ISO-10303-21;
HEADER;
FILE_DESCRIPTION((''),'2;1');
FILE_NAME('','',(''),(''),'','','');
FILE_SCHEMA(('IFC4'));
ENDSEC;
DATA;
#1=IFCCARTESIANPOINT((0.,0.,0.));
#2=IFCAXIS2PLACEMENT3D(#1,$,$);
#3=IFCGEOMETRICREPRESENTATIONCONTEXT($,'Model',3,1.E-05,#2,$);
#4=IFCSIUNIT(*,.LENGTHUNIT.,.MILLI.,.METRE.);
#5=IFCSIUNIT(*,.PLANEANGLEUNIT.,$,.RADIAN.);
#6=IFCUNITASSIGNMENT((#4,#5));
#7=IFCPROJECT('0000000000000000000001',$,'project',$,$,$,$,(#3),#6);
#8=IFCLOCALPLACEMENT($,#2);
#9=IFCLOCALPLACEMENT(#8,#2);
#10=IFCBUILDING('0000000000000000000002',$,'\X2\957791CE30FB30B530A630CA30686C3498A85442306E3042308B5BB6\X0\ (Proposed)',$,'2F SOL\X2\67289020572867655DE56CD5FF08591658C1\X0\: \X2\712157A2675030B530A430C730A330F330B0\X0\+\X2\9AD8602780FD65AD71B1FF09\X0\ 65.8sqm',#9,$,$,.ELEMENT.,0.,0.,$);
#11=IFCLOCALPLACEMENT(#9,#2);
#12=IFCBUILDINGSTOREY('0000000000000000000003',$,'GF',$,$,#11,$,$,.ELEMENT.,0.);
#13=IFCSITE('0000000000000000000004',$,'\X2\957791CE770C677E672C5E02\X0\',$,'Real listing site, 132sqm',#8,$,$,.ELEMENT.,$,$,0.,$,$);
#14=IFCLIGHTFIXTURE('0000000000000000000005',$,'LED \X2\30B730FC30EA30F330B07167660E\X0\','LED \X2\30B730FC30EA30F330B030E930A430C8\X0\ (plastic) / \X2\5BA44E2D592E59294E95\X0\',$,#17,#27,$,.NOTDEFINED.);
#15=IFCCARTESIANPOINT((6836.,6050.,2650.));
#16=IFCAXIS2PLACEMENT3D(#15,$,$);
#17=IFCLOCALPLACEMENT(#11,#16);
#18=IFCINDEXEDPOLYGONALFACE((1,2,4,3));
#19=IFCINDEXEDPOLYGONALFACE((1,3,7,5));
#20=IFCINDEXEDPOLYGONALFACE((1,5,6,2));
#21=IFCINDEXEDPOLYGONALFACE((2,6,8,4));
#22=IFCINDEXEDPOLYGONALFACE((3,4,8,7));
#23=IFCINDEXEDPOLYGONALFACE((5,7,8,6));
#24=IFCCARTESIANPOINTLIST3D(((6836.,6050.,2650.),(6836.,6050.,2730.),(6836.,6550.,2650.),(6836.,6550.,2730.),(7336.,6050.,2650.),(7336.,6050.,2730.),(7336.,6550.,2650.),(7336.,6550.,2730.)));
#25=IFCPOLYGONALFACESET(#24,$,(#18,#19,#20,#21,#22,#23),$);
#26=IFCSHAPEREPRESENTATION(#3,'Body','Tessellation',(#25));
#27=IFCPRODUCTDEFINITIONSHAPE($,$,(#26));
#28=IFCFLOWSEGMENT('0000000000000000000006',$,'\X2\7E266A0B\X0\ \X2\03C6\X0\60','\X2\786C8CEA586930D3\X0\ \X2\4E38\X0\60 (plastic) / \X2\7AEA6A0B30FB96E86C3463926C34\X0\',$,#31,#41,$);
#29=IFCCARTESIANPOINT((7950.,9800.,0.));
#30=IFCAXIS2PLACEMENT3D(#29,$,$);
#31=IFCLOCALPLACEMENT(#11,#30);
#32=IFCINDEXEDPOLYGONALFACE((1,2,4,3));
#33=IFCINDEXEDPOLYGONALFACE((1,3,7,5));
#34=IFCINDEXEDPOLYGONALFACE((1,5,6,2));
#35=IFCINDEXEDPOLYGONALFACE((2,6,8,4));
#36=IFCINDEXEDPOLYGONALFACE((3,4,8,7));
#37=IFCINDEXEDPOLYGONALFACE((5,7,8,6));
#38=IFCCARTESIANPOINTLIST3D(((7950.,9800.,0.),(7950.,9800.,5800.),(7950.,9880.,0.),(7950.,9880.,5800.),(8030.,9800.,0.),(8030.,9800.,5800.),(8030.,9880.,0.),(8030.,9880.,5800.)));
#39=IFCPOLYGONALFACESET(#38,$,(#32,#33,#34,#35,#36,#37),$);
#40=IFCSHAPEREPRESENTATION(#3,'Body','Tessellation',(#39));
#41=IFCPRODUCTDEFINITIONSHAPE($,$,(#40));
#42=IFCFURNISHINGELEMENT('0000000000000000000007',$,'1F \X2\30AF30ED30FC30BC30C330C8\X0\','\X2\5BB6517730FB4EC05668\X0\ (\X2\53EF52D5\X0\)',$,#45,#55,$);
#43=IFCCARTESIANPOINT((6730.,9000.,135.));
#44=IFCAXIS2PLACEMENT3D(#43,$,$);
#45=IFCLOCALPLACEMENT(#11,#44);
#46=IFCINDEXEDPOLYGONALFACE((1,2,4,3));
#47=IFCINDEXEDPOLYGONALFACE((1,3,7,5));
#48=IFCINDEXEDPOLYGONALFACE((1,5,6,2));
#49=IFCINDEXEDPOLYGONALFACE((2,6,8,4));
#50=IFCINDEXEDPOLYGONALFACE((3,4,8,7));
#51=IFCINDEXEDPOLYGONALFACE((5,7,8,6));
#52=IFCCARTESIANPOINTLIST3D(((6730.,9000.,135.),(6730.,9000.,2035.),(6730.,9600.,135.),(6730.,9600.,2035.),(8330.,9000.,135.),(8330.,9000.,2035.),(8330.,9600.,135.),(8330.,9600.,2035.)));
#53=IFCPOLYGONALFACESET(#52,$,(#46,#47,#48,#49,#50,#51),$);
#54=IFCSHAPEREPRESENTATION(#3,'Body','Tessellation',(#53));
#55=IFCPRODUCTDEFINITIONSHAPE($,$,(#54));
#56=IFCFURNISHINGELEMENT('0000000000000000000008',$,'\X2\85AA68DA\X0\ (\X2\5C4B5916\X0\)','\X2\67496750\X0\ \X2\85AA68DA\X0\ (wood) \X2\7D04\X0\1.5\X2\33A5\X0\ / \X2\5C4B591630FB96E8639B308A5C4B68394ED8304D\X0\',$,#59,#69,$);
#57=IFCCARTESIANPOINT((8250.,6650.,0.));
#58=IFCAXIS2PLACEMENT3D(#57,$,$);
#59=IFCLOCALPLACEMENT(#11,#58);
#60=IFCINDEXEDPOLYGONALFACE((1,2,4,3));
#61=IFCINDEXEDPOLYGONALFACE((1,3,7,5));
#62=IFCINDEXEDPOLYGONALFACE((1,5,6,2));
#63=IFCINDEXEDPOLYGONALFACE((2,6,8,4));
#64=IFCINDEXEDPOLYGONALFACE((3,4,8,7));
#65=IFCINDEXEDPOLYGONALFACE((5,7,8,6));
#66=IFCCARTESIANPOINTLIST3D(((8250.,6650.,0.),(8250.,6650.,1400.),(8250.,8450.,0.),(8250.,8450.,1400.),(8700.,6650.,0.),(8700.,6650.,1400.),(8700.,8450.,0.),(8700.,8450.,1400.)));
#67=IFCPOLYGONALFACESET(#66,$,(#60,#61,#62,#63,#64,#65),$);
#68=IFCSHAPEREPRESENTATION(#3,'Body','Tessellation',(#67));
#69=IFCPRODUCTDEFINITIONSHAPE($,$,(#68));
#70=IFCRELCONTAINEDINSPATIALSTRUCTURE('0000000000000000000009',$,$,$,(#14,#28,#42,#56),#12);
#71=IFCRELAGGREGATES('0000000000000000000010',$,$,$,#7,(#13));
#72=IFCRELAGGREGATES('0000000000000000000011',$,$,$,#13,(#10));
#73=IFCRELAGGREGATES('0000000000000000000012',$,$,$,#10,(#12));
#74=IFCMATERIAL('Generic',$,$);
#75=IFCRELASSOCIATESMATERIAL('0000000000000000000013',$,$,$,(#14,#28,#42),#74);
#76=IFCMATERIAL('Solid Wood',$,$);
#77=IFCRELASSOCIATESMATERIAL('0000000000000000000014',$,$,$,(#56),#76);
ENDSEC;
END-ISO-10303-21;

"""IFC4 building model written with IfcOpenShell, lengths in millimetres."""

from ifc_helpers import new_model, si_unit, frame, frame_2d, origin, place, context, project, spatial, rectangle, extrude, material, element, save


model = new_model("IFC4")

# Units and contexts
model_context = context("Model", 3, precision=1e-05, world=origin())
ifc_project = project(units=[si_unit("LENGTHUNIT", "METRE", prefix="MILLI"), si_unit("PLANEANGLEUNIT", "RADIAN")], contexts=[model_context])

# Site, building, storey
site_placement = place(None, origin())
site = spatial("IfcSite", under=ifc_project, at=site_placement, Name="長野県松本市", ObjectType="Real listing site, 132sqm", CompositionType="ELEMENT", RefElevation=0.0)
building_placement = place(site_placement, origin())
building = spatial("IfcBuilding", under=site, at=building_placement, Name="長野・サウナと水風呂のある家 (Proposed)", ObjectType="2F SOL木造在来工法（外壁: 無垢材サイディング+高性能断熱） 65.8sqm", CompositionType="ELEMENT", ElevationOfRefHeight=0.0, ElevationOfTerrain=0.0)
storey_placement = place(building_placement, origin())
storey = spatial("IfcBuildingStorey", under=building, at=storey_placement, Name="GF", CompositionType="ELEMENT", Elevation=0.0)

# Shared definitions
ifc_material_1 = material(Name="Solid Wood")

# Shared definitions
ifc_material_2 = material(Name="Generic")

# Light fixture
light_fixture_placement = place(storey_placement, frame((6836.0, 6050.0, 2650.0)))
element("IfcLightFixture", 1, at=light_fixture_placement, inside=storey, material=ifc_material_2, Name="LED シーリング照明", Description="LED シーリングライト (plastic) / 室中央天井", PredefinedType="NOTDEFINED", context=model_context, shape_type="SweptSolid", body=[
    extrude(rectangle(XDim=500.0, YDim=500.0, at=frame_2d((250.0, 250.0))), frame((6836.0, 6050.0, 2650.0)), (0.0, 0.0, 1.0), 80.0),
])

# Flow segment
flow_segment_placement = place(storey_placement, frame((7950.0, 9800.0, 0.0)))
element("IfcFlowSegment", 2, at=flow_segment_placement, inside=storey, material=ifc_material_2, Name="縦樋 φ60", Description="硬質塩ビ 丸60 (plastic) / 竪樋・雨水排水", context=model_context, shape_type="SweptSolid", body=[
    extrude(rectangle(XDim=80.0, YDim=80.0, at=frame_2d((40.0, 40.0))), frame((7950.0, 9800.0, 0.0)), (0.0, 0.0, 1.0), 5800.0),
])

# Furnishing elements
furnishing_1_placement = place(storey_placement, frame((6730.0, 9000.0, 135.0)))
element("IfcFurnishingElement", 3, at=furnishing_1_placement, inside=storey, material=ifc_material_2, Name="1F クローゼット", Description="家具・什器 (可動)", context=model_context, shape_type="SweptSolid", body=[
    extrude(rectangle(XDim=1600.0, YDim=600.0, at=frame_2d((800.0, 300.0))), frame((6730.0, 9000.0, 135.0)), (0.0, 0.0, 1.0), 1900.0),
])
furnishing_2_placement = place(storey_placement, frame((8250.0, 6650.0, 0.0)))
element("IfcFurnishingElement", 4, at=furnishing_2_placement, inside=storey, material=ifc_material_1, Name="薪棚 (屋外)", Description="杉材 薪棚 (wood) 約1.5㎥ / 屋外・雨掛り屋根付き", context=model_context, shape_type="SweptSolid", body=[
    extrude(rectangle(XDim=450.0, YDim=1800.0, at=frame_2d((225.0, 900.0))), frame((8250.0, 6650.0, 0.0)), (0.0, 0.0, 1.0), 1400.0),
])

save(model, "model.ifc")
